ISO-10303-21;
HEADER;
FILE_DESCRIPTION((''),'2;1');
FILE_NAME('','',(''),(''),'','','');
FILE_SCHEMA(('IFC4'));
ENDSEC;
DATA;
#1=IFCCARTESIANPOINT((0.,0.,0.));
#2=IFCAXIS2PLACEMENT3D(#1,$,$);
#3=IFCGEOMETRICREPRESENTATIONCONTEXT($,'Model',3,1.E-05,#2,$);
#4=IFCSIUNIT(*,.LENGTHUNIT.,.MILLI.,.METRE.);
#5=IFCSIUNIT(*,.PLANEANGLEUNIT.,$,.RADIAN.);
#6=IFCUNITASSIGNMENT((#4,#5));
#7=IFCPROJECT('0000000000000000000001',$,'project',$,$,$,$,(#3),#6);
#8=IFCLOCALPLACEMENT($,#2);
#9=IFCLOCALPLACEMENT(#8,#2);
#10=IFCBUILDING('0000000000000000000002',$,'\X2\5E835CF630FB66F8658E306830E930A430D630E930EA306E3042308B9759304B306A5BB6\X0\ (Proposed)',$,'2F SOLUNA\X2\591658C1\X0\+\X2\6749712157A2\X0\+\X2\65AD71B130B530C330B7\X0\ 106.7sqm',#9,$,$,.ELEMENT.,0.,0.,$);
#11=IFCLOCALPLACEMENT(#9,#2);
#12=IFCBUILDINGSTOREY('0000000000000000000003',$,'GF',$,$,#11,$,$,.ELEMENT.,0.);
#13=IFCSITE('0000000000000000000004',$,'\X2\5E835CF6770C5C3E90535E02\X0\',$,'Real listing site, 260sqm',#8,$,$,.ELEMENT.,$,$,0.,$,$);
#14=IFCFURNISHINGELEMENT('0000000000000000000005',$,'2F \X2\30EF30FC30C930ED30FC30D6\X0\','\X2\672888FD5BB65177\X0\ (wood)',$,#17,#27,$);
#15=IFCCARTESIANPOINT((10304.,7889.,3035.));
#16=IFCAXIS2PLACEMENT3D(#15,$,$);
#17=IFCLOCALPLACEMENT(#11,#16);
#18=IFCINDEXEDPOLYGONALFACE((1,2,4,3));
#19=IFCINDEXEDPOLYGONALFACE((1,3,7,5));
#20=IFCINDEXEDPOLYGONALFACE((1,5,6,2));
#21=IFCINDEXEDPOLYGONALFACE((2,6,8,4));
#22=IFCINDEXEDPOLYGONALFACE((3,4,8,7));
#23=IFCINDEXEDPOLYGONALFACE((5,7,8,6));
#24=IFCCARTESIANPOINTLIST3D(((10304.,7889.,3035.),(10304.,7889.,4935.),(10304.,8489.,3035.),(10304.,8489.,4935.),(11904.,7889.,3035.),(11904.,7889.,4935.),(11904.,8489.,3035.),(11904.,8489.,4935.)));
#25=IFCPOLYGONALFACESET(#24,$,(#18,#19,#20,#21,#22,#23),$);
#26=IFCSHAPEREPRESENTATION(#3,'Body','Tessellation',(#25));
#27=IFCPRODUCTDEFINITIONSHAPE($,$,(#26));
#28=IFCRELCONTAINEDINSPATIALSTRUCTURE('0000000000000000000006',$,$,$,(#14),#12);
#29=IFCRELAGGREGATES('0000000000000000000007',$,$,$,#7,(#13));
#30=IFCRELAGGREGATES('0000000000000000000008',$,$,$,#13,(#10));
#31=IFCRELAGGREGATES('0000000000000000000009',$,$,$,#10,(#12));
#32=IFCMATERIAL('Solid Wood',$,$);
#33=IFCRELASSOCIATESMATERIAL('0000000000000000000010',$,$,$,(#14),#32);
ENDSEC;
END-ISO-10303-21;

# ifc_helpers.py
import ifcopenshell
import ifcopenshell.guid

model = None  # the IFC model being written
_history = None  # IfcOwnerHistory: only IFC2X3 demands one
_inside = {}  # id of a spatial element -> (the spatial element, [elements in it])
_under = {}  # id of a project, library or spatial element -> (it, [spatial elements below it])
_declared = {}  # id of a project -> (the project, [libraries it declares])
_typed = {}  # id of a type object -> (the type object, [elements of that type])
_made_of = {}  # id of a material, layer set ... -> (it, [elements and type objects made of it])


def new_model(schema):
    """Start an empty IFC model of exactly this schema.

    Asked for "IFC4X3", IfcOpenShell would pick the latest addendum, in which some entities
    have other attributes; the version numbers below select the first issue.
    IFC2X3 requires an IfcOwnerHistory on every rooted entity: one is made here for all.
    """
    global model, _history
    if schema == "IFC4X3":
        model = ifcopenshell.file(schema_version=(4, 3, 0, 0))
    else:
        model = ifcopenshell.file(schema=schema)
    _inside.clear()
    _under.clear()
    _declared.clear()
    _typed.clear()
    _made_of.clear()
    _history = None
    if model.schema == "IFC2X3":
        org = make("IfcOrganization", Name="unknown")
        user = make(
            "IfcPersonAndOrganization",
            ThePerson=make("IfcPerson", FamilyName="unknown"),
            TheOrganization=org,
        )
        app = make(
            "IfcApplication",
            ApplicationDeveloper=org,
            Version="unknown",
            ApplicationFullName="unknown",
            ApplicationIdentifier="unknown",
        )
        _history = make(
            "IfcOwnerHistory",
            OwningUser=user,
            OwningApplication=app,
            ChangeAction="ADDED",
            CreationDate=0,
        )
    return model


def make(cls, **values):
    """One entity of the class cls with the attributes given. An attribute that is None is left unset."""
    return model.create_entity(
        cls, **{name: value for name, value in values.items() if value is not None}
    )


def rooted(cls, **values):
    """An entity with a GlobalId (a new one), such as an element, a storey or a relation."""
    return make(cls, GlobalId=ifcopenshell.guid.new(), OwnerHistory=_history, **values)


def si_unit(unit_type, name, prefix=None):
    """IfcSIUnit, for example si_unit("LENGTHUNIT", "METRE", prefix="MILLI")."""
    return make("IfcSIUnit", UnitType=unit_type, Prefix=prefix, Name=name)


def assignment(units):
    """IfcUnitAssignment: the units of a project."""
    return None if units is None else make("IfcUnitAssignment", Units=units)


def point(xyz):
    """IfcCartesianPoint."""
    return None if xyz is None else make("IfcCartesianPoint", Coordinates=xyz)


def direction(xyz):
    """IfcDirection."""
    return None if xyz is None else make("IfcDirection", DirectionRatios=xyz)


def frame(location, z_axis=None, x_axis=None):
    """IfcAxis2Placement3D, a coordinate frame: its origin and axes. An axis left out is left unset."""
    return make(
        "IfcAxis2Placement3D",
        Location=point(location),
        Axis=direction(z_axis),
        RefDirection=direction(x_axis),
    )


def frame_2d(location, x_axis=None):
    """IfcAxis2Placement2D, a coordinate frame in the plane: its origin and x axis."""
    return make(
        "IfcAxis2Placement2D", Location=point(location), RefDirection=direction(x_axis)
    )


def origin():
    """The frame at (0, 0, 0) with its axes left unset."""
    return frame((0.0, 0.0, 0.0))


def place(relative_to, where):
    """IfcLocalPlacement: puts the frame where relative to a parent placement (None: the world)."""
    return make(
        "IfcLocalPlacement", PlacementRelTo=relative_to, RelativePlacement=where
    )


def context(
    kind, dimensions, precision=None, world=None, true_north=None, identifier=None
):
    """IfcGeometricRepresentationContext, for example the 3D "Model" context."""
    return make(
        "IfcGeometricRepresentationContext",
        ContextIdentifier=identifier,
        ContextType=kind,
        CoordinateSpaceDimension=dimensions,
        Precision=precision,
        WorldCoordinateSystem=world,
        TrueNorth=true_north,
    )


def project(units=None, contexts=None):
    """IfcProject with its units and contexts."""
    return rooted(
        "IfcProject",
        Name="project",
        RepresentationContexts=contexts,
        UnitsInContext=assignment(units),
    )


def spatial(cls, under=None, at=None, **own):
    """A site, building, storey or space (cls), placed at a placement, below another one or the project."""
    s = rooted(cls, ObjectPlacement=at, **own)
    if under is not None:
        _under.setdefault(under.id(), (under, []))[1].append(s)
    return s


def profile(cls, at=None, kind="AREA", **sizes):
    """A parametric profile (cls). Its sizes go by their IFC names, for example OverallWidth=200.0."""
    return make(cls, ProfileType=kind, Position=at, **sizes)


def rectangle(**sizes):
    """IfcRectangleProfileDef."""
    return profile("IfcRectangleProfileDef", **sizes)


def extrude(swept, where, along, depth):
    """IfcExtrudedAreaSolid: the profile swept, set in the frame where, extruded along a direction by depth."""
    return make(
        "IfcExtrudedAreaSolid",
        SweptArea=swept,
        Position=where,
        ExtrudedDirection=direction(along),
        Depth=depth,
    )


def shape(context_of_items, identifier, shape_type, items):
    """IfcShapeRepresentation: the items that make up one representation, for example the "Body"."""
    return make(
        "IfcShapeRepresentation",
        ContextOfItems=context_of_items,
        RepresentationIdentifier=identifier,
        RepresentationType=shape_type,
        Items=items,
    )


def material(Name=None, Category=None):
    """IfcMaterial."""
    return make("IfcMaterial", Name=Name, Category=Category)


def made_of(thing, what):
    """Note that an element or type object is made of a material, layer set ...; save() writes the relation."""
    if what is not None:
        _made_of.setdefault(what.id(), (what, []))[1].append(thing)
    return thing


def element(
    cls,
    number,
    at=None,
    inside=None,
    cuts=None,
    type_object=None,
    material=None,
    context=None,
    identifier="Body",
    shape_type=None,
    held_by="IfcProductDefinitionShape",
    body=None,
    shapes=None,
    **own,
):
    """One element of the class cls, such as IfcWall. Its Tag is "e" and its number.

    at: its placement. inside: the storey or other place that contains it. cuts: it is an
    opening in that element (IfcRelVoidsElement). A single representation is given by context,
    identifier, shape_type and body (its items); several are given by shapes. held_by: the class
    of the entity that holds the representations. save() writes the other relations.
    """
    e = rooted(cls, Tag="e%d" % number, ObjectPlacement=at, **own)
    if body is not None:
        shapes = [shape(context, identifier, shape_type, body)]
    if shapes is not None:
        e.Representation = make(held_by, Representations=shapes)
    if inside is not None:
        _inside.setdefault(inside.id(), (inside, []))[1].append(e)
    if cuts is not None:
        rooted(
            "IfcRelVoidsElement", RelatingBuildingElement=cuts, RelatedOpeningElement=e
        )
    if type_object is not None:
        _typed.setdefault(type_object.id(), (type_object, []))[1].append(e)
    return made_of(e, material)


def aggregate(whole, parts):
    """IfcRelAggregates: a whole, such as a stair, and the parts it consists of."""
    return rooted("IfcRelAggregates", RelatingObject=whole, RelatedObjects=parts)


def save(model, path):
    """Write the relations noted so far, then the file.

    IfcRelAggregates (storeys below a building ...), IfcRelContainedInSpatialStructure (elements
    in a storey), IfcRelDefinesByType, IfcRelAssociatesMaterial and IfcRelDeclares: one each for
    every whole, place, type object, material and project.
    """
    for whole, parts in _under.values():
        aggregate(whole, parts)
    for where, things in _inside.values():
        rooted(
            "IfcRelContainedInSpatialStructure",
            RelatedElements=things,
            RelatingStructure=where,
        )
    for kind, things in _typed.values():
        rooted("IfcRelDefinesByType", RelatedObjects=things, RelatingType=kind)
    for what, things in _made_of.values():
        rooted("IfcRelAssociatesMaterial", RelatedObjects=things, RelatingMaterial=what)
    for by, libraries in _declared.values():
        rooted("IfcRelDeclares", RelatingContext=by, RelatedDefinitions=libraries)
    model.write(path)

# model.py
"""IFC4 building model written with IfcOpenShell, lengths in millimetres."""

from ifc_helpers import new_model, si_unit, frame, frame_2d, origin, place, context, project, spatial, rectangle, extrude, material, element, save


model = new_model("IFC4")

# Units and contexts
model_context = context("Model", 3, precision=1e-05, world=origin())
ifc_project = project(units=[si_unit("LENGTHUNIT", "METRE", prefix="MILLI"), si_unit("PLANEANGLEUNIT", "RADIAN")], contexts=[model_context])

# Site, building, storey
site_placement = place(None, origin())
site = spatial("IfcSite", under=ifc_project, at=site_placement, Name="広島県尾道市", ObjectType="Real listing site, 260sqm", CompositionType="ELEMENT", RefElevation=0.0)
building_placement = place(site_placement, origin())
building = spatial("IfcBuilding", under=site, at=building_placement, Name="広島・書斎とライブラリのある静かな家 (Proposed)", ObjectType="2F SOLUNA外壁+杉無垢+断熱サッシ 106.7sqm", CompositionType="ELEMENT", ElevationOfRefHeight=0.0, ElevationOfTerrain=0.0)
storey_placement = place(building_placement, origin())
storey = spatial("IfcBuildingStorey", under=building, at=storey_placement, Name="GF", CompositionType="ELEMENT", Elevation=0.0)

# Shared definitions
ifc_material_1 = material(Name="Solid Wood")

# Furnishing element
furnishing_placement = place(storey_placement, frame((10304.0, 7889.0, 3035.0)))
element("IfcFurnishingElement", 1, at=furnishing_placement, inside=storey, material=ifc_material_1, Name="2F ワードローブ", Description="木製家具 (wood)", context=model_context, shape_type="SweptSolid", body=[
    extrude(rectangle(XDim=1600.0, YDim=600.0, at=frame_2d((800.0, 300.0))), frame((10304.0, 7889.0, 3035.0)), (0.0, 0.0, 1.0), 1900.0),
])

save(model, "model.ifc")
